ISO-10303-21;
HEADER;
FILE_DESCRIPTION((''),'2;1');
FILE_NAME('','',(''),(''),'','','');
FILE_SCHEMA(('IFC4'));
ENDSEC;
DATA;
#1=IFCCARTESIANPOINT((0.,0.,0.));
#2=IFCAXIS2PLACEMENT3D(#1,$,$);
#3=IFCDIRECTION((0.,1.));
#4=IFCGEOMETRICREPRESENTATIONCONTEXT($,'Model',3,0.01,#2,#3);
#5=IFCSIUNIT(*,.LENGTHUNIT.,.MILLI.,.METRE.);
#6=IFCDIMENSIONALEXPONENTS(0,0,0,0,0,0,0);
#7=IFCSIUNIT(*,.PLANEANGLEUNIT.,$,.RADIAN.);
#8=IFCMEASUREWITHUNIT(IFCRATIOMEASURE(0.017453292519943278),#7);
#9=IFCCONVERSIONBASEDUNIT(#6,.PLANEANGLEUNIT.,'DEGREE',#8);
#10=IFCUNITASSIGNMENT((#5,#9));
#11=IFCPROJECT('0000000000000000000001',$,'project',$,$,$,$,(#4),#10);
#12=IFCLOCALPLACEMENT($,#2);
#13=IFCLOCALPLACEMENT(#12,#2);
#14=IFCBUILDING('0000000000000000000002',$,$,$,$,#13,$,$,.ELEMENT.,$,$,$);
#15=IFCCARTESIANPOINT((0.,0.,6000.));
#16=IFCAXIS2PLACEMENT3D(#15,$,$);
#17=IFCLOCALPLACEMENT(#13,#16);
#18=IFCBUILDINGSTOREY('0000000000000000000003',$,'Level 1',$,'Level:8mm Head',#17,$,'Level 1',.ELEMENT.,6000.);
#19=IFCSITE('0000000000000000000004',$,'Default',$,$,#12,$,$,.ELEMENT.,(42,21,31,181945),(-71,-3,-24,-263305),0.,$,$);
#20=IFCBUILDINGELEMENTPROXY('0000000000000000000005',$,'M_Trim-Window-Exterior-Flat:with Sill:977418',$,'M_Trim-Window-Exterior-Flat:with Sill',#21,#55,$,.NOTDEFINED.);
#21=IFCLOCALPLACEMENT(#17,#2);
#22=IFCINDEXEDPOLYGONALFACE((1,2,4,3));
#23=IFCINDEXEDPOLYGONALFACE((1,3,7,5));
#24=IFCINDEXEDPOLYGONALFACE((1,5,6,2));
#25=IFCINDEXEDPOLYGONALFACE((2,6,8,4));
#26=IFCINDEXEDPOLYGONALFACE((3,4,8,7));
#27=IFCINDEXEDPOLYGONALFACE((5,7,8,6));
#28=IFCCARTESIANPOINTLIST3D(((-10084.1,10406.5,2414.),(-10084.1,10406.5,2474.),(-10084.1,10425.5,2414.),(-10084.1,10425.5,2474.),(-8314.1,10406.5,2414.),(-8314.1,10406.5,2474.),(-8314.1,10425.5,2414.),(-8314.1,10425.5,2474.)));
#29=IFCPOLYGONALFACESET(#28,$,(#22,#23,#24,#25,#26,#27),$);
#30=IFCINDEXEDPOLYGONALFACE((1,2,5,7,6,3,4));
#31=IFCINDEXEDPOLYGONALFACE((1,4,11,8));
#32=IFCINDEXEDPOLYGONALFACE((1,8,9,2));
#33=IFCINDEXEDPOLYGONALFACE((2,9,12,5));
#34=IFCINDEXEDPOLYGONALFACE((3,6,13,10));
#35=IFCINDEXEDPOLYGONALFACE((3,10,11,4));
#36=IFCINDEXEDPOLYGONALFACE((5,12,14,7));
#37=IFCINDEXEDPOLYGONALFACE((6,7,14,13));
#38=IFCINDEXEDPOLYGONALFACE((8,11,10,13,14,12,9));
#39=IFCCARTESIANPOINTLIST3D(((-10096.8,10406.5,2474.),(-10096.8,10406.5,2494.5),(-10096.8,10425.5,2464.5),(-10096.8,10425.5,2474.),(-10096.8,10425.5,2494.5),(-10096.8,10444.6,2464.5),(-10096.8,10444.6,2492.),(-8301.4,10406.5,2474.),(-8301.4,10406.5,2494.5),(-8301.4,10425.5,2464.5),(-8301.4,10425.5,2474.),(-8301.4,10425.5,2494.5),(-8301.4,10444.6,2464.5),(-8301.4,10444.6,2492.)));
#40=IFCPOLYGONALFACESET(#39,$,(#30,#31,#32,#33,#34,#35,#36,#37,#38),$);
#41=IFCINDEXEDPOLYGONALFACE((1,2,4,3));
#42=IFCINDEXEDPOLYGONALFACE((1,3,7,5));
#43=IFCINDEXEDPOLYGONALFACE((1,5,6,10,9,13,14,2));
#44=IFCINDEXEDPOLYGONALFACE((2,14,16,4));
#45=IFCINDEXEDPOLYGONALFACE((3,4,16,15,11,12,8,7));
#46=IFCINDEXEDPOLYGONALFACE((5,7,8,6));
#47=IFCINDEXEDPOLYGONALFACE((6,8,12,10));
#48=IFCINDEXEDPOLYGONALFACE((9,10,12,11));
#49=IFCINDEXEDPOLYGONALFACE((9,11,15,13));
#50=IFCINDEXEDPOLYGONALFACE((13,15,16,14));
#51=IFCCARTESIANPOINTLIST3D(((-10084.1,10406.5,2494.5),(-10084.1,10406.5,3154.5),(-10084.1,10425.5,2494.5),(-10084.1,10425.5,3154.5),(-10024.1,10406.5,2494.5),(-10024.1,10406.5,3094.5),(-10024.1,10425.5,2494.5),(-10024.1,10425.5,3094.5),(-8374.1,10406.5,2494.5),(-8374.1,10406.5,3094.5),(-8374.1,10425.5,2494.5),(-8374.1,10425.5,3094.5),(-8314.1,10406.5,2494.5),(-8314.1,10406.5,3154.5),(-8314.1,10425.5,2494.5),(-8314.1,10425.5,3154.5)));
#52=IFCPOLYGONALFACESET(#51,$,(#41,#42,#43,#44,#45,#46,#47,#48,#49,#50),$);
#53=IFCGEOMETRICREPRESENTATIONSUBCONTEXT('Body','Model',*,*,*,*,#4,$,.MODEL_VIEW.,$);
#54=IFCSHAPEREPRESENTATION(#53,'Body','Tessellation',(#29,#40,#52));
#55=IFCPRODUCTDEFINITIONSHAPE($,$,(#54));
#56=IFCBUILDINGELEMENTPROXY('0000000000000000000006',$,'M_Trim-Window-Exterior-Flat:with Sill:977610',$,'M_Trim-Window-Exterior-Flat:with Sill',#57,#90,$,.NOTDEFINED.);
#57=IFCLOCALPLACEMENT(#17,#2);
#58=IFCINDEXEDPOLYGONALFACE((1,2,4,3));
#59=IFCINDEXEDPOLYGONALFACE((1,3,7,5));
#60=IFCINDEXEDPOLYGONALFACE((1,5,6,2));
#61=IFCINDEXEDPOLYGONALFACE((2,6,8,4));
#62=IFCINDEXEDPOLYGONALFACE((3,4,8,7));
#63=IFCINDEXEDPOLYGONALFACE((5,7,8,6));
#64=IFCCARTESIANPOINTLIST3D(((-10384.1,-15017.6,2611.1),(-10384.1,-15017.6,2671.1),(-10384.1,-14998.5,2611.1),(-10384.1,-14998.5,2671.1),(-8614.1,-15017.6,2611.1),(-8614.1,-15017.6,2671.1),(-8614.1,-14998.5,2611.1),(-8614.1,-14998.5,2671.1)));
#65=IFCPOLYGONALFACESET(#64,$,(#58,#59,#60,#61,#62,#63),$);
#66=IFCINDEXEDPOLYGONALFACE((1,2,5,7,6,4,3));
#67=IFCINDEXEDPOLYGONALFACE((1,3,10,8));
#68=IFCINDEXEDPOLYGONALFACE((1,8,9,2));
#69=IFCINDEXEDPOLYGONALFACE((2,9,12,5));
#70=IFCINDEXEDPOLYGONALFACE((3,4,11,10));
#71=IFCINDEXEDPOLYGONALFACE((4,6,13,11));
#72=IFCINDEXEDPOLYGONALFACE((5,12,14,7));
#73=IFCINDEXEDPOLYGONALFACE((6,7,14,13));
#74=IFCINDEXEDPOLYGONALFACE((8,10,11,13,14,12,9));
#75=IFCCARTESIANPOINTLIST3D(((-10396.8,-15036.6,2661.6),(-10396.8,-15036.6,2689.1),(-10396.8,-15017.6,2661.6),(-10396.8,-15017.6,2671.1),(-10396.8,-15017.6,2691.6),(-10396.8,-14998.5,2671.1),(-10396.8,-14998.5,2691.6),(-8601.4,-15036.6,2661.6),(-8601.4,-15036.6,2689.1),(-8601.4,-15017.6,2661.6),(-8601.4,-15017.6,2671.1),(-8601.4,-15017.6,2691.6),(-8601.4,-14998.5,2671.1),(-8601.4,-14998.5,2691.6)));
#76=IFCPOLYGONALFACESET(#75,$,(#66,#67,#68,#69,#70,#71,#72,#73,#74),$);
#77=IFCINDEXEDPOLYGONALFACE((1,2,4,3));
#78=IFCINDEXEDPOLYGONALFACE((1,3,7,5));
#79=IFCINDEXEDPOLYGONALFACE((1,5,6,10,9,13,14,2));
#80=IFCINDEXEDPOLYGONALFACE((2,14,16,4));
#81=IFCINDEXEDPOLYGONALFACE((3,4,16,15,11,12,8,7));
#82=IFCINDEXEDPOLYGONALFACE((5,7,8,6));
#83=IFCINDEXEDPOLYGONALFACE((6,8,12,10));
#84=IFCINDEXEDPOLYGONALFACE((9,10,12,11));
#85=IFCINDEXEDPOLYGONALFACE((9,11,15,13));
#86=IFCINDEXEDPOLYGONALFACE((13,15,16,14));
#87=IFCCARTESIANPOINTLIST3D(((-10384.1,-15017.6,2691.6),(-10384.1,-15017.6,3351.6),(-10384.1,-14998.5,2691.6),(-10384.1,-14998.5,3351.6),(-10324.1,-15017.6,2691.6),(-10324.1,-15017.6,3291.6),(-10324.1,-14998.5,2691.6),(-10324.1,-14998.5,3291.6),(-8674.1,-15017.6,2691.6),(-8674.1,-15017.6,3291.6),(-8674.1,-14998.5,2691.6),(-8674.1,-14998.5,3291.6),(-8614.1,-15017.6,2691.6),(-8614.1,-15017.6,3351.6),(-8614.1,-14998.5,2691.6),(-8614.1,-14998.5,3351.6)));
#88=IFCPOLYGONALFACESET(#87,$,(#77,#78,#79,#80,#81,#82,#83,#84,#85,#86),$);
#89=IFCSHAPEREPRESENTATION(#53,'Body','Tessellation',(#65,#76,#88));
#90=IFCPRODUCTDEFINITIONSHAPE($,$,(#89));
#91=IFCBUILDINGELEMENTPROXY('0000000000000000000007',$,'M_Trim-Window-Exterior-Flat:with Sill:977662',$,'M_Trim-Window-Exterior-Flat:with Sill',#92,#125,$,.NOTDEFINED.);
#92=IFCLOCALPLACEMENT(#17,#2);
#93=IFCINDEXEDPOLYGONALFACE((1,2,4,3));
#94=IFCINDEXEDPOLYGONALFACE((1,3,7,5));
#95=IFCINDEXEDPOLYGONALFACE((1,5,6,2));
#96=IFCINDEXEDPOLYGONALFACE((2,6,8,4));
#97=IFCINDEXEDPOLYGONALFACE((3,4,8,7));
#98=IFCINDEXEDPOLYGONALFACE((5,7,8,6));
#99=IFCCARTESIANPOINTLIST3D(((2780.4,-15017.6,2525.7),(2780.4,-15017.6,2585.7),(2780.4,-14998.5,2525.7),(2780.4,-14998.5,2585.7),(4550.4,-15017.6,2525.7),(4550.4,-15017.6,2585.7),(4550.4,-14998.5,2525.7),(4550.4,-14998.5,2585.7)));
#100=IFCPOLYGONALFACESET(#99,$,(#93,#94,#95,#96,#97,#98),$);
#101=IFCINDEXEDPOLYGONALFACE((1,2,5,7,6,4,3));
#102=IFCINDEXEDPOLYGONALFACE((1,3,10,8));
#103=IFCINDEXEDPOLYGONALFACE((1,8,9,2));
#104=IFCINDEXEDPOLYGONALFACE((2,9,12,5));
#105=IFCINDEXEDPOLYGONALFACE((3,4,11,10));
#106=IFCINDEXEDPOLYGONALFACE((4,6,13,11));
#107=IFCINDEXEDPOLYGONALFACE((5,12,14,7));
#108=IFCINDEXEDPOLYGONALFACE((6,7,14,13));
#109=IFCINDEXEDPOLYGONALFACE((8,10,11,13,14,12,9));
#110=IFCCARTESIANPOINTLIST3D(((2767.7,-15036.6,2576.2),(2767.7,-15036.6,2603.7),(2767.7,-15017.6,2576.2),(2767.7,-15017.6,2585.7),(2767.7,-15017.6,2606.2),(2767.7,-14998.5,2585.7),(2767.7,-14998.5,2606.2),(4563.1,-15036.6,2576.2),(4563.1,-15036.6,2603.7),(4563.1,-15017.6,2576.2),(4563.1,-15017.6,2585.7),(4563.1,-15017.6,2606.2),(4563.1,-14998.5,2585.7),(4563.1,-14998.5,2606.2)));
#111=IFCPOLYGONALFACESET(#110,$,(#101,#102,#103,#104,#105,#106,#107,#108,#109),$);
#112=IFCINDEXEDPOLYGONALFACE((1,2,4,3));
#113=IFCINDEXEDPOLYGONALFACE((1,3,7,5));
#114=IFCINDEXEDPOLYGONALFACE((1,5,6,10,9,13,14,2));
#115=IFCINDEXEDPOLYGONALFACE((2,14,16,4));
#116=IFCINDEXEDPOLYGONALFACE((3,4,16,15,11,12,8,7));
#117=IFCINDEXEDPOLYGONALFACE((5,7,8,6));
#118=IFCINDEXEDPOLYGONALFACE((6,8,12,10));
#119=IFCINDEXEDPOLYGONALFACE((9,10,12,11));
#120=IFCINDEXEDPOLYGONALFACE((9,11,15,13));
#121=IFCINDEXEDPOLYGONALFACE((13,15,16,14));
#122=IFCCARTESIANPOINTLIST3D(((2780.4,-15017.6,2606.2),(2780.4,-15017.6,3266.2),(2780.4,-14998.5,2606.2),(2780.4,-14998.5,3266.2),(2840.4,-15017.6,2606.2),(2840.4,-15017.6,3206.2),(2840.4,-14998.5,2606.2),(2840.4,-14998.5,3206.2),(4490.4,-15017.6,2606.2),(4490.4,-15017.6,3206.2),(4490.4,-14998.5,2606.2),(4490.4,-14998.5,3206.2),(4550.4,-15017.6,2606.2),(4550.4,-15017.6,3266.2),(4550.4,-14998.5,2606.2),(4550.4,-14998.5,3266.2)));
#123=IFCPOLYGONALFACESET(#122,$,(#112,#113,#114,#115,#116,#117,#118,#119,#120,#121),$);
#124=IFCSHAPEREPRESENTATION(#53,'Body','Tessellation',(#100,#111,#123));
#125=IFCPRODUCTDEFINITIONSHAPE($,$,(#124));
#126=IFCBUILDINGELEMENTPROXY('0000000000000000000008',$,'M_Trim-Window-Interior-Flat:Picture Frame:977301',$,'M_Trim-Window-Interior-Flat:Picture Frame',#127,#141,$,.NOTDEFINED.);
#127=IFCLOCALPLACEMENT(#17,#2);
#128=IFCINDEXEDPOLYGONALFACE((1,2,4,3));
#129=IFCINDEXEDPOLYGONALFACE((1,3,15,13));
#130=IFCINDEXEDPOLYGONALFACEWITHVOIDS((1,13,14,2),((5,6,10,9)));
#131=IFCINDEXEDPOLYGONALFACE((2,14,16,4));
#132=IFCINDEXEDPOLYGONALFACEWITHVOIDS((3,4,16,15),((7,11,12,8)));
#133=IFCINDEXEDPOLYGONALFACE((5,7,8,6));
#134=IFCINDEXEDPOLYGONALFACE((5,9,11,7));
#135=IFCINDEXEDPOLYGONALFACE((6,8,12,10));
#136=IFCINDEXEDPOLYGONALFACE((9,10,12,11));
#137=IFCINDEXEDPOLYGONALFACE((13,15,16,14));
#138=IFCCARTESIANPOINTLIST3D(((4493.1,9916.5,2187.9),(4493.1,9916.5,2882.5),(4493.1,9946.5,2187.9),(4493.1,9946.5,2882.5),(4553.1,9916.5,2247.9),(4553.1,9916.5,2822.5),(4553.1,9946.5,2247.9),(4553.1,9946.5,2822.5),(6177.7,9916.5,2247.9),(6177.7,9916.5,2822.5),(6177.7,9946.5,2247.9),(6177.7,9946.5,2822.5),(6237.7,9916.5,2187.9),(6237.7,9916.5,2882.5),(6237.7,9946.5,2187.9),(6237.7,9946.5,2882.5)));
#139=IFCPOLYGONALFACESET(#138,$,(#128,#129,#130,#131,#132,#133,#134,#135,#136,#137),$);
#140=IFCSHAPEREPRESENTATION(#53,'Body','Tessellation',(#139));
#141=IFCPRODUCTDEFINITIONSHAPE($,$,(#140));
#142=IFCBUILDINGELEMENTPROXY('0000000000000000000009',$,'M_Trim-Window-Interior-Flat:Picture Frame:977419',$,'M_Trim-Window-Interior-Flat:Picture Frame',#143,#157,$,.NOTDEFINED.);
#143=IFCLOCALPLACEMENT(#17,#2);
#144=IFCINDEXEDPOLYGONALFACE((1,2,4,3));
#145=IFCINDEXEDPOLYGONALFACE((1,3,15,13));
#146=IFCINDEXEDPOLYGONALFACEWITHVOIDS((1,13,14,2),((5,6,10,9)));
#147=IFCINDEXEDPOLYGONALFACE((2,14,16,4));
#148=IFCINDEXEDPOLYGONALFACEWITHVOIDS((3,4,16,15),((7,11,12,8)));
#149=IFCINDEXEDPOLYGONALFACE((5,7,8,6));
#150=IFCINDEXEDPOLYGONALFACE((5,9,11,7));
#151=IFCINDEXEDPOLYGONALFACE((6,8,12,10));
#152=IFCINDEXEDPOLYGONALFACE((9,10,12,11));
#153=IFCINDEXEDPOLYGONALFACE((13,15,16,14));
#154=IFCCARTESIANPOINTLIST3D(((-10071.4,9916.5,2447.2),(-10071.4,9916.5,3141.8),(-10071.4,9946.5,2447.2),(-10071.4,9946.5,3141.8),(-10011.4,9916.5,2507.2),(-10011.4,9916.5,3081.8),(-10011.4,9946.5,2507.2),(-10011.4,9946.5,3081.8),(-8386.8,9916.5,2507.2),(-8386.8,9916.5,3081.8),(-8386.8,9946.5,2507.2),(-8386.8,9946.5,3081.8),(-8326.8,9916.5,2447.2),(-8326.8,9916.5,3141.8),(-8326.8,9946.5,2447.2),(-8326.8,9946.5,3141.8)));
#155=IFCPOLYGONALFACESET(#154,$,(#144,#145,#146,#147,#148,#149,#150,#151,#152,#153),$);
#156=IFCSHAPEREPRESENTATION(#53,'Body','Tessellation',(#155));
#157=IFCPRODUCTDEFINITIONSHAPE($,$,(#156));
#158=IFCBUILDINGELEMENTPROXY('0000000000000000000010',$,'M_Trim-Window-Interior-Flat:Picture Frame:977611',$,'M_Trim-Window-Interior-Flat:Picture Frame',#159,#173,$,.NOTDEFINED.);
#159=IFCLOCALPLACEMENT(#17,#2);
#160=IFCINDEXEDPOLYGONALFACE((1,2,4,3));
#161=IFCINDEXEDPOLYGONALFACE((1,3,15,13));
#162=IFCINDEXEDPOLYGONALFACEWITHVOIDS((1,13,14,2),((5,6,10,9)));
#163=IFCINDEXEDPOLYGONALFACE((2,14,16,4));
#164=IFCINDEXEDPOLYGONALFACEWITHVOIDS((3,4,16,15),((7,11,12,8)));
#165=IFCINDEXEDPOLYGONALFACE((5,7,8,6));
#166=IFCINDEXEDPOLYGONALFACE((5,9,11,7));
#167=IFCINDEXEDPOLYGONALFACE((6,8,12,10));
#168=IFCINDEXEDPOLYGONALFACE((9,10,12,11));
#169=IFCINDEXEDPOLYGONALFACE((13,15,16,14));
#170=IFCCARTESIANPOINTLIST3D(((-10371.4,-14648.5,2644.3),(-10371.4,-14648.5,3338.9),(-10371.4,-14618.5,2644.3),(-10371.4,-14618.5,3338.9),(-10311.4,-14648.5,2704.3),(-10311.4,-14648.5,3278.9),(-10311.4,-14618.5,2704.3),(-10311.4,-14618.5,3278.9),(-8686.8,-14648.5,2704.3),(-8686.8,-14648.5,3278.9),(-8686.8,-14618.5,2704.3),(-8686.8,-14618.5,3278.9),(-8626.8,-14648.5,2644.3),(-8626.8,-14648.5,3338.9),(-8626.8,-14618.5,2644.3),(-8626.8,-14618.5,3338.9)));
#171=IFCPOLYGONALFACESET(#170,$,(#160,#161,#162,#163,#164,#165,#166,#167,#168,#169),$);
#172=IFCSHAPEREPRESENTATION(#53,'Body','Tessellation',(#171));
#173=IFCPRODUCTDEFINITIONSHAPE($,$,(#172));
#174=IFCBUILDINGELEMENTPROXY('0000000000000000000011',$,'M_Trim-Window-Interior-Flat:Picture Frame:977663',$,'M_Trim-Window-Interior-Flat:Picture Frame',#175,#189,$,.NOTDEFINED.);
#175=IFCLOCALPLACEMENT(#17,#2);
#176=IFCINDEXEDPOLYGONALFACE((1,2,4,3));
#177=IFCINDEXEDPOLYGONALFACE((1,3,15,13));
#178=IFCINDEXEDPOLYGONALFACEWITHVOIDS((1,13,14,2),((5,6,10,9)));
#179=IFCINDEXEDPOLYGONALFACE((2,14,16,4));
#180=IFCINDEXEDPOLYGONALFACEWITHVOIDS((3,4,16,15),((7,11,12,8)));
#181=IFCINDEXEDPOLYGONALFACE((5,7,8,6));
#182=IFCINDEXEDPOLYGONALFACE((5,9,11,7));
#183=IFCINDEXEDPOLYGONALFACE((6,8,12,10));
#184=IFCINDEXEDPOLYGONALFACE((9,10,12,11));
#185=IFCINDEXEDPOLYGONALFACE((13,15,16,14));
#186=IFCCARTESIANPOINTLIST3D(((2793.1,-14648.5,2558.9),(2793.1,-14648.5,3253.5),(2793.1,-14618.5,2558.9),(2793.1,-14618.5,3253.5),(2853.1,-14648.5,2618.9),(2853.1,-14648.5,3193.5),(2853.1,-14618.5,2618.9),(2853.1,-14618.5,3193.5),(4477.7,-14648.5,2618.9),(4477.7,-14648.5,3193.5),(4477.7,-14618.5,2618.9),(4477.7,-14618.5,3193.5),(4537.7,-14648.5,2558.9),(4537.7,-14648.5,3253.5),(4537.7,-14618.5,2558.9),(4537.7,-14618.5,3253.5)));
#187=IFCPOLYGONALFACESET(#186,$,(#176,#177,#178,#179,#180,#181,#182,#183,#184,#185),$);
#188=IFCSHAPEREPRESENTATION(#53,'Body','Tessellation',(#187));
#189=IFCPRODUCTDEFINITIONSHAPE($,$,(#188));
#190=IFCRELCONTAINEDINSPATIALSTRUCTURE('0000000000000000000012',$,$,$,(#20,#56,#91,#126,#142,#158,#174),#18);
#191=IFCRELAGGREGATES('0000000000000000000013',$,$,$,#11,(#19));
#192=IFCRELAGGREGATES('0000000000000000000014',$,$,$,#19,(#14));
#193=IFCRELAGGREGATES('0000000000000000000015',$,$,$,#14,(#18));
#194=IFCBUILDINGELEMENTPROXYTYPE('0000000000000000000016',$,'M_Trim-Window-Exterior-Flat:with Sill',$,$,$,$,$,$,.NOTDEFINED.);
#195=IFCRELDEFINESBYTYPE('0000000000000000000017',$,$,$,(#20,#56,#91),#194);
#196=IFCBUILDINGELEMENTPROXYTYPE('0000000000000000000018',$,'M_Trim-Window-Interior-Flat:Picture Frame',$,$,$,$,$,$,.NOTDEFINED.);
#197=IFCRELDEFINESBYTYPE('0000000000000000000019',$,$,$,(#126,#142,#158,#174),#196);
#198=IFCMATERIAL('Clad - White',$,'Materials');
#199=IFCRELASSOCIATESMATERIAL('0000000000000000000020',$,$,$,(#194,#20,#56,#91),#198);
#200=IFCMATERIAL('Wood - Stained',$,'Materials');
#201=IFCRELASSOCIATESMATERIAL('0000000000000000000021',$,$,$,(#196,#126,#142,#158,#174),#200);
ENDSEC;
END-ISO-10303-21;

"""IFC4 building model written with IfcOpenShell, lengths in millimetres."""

from ifc_helpers import new_model, entity, si_unit, converted_unit, direction, frame, origin, place, context, subcontext, project, spatial, indexed_curve, outline, extrude, source, transform, mapped, material, type_object, type_shapes, element, save


model = new_model("IFC4")

# Units and contexts
model_context = context("Model", 3, precision=0.01, world=origin(), true_north=direction((0.0, 1.0)))
body_context = subcontext(model_context, "Body", "Model", "MODEL_VIEW")
ifc_project = project(units=[si_unit("LENGTHUNIT", "METRE", prefix="MILLI"), converted_unit("PLANEANGLEUNIT", "DEGREE", entity("IfcRatioMeasure", 0.017453292519943278), si_unit("PLANEANGLEUNIT", "RADIAN"), dimensions=[0, 0, 0, 0, 0, 0, 0])], contexts=[model_context])

# Site, building, storey
site_placement = place(None, origin())
site = spatial("IfcSite", under=ifc_project, at=site_placement, Name="Default", CompositionType="ELEMENT", RefLatitude=(42, 21, 31, 181945), RefLongitude=(-71, -3, -24, -263305), RefElevation=0.0)
building_placement = place(site_placement, origin())
building = spatial("IfcBuilding", under=site, at=building_placement, CompositionType="ELEMENT")
storey_placement = place(building_placement, frame((0.0, 0.0, 6000.0)))
storey = spatial("IfcBuildingStorey", under=building, at=storey_placement, Name="Level 1", ObjectType="Level:8mm Head", LongName="Level 1", CompositionType="ELEMENT", Elevation=6000.0)

# Building element proxies
ifc_material_1 = material(Name="Clad - White", Category="Materials")
building_element_proxy_type_1 = type_object("IfcBuildingElementProxyType", Name="M_Trim-Window-Exterior-Flat:with Sill", PredefinedType="NOTDEFINED", material=ifc_material_1)
shared_shape_1 = source(origin(), body_context, "Body", "SweptSolid", [
    extrude(outline(indexed_curve([(-885.0, -30.0), (885.0, -30.0), (885.0, 30.0), (-885.0, 30.0), (-885.0, -30.0)], self_intersect=False)), frame((0.0, -650.4, 0.0), z_axis=(0.0, 0.0, 1.0), x_axis=(-1.0, 0.0, 0.0)), (0.0, 0.0, 1.0), 19.0),
    extrude(outline(indexed_curve([(-19.0, -15.2), (0.0, -15.2), (0.0, -5.7), (19.0, -5.7), (19.0, 14.8), (0.0, 14.8), (-19.0, 12.3), (-19.0, -15.2)], self_intersect=False)), frame((-897.7, -614.8, 19.0), z_axis=(1.0, 0.0, 0.0), x_axis=(0.0, 0.0, -1.0)), (0.0, 0.0, 1.0), 1795.4),
    extrude(outline(indexed_curve([(-345.0, -885.0), (315.0, -885.0), (315.0, -825.0), (-285.0, -825.0), (-285.0, 825.0), (315.0, 825.0), (315.0, 885.0), (-345.0, 885.0), (-345.0, -885.0)], self_intersect=False)), frame((0.0, -285.0, 0.0), z_axis=(0.0, 0.0, 1.0), x_axis=(0.0, -1.0, 0.0)), (0.0, 0.0, 1.0), 19.0),
])
type_shapes(building_element_proxy_type_1, [shared_shape_1])
for number, where, z_axis, x_axis, name in (
    (1, (-9199.1, 10406.5, 3094.5), (0.0, 1.0, 0.0), (-1.0, 0.0, 0.0), "M_Trim-Window-Exterior-Flat:with Sill:977418"),
    (2, (-9499.1, -14998.5, 3291.6), (0.0, -1.0, 0.0), (1.0, 0.0, 0.0), "M_Trim-Window-Exterior-Flat:with Sill:977610"),
    (3, (3665.4, -14998.5, 3206.2), (0.0, -1.0, 0.0), (1.0, 0.0, 0.0), "M_Trim-Window-Exterior-Flat:with Sill:977662"),
):
    element("IfcBuildingElementProxy", number, at=place(storey_placement, frame(where, z_axis=z_axis, x_axis=x_axis)), inside=storey, type_object=building_element_proxy_type_1, material=ifc_material_1, Name=name, ObjectType="M_Trim-Window-Exterior-Flat:with Sill", PredefinedType="NOTDEFINED", context=body_context, shape_type="MappedRepresentation", body=[
        mapped(shared_shape_1, transform((0.0, 0.0, 0.0), scale=1.0)),
    ])
ifc_material_2 = material(Name="Wood - Stained", Category="Materials")
building_element_proxy_type_2 = type_object("IfcBuildingElementProxyType", Name="M_Trim-Window-Interior-Flat:Picture Frame", PredefinedType="NOTDEFINED", material=ifc_material_2)
shared_shape_2 = source(origin(), body_context, "Body", "SweptSolid", [
    extrude(outline(indexed_curve([(-872.3, -347.3), (872.3, -347.3), (872.3, 347.3), (-872.3, 347.3), (-872.3, -347.3)], self_intersect=False), holes=[indexed_curve([(-812.3, -287.3), (-812.3, 287.3), (812.3, 287.3), (812.3, -287.3), (-812.3, -287.3)], self_intersect=False)]), frame((0.0, -300.0, 0.0), z_axis=(0.0, 0.0, 1.0), x_axis=(-1.0, 0.0, 0.0)), (0.0, 0.0, 1.0), 30.0),
])
type_shapes(building_element_proxy_type_2, [shared_shape_2])
for number, where, z_axis, x_axis, name in (
    (4, (5365.4, 9946.5, 2835.2), (0.0, -1.0, 0.0), (1.0, 0.0, 0.0), "M_Trim-Window-Interior-Flat:Picture Frame:977301"),
    (5, (-9199.1, 9946.5, 3094.5), (0.0, -1.0, 0.0), (1.0, 0.0, 0.0), "M_Trim-Window-Interior-Flat:Picture Frame:977419"),
    (6, (-9499.1, -14648.5, 3291.6), (0.0, 1.0, 0.0), (-1.0, 0.0, 0.0), "M_Trim-Window-Interior-Flat:Picture Frame:977611"),
    (7, (3665.4, -14648.5, 3206.2), (0.0, 1.0, 0.0), (-1.0, 0.0, 0.0), "M_Trim-Window-Interior-Flat:Picture Frame:977663"),
):
    element("IfcBuildingElementProxy", number, at=place(storey_placement, frame(where, z_axis=z_axis, x_axis=x_axis)), inside=storey, type_object=building_element_proxy_type_2, material=ifc_material_2, Name=name, ObjectType="M_Trim-Window-Interior-Flat:Picture Frame", PredefinedType="NOTDEFINED", context=body_context, shape_type="MappedRepresentation", body=[
        mapped(shared_shape_2, transform((0.0, 0.0, 0.0), scale=1.0)),
    ])

save(model, "model.ifc")
